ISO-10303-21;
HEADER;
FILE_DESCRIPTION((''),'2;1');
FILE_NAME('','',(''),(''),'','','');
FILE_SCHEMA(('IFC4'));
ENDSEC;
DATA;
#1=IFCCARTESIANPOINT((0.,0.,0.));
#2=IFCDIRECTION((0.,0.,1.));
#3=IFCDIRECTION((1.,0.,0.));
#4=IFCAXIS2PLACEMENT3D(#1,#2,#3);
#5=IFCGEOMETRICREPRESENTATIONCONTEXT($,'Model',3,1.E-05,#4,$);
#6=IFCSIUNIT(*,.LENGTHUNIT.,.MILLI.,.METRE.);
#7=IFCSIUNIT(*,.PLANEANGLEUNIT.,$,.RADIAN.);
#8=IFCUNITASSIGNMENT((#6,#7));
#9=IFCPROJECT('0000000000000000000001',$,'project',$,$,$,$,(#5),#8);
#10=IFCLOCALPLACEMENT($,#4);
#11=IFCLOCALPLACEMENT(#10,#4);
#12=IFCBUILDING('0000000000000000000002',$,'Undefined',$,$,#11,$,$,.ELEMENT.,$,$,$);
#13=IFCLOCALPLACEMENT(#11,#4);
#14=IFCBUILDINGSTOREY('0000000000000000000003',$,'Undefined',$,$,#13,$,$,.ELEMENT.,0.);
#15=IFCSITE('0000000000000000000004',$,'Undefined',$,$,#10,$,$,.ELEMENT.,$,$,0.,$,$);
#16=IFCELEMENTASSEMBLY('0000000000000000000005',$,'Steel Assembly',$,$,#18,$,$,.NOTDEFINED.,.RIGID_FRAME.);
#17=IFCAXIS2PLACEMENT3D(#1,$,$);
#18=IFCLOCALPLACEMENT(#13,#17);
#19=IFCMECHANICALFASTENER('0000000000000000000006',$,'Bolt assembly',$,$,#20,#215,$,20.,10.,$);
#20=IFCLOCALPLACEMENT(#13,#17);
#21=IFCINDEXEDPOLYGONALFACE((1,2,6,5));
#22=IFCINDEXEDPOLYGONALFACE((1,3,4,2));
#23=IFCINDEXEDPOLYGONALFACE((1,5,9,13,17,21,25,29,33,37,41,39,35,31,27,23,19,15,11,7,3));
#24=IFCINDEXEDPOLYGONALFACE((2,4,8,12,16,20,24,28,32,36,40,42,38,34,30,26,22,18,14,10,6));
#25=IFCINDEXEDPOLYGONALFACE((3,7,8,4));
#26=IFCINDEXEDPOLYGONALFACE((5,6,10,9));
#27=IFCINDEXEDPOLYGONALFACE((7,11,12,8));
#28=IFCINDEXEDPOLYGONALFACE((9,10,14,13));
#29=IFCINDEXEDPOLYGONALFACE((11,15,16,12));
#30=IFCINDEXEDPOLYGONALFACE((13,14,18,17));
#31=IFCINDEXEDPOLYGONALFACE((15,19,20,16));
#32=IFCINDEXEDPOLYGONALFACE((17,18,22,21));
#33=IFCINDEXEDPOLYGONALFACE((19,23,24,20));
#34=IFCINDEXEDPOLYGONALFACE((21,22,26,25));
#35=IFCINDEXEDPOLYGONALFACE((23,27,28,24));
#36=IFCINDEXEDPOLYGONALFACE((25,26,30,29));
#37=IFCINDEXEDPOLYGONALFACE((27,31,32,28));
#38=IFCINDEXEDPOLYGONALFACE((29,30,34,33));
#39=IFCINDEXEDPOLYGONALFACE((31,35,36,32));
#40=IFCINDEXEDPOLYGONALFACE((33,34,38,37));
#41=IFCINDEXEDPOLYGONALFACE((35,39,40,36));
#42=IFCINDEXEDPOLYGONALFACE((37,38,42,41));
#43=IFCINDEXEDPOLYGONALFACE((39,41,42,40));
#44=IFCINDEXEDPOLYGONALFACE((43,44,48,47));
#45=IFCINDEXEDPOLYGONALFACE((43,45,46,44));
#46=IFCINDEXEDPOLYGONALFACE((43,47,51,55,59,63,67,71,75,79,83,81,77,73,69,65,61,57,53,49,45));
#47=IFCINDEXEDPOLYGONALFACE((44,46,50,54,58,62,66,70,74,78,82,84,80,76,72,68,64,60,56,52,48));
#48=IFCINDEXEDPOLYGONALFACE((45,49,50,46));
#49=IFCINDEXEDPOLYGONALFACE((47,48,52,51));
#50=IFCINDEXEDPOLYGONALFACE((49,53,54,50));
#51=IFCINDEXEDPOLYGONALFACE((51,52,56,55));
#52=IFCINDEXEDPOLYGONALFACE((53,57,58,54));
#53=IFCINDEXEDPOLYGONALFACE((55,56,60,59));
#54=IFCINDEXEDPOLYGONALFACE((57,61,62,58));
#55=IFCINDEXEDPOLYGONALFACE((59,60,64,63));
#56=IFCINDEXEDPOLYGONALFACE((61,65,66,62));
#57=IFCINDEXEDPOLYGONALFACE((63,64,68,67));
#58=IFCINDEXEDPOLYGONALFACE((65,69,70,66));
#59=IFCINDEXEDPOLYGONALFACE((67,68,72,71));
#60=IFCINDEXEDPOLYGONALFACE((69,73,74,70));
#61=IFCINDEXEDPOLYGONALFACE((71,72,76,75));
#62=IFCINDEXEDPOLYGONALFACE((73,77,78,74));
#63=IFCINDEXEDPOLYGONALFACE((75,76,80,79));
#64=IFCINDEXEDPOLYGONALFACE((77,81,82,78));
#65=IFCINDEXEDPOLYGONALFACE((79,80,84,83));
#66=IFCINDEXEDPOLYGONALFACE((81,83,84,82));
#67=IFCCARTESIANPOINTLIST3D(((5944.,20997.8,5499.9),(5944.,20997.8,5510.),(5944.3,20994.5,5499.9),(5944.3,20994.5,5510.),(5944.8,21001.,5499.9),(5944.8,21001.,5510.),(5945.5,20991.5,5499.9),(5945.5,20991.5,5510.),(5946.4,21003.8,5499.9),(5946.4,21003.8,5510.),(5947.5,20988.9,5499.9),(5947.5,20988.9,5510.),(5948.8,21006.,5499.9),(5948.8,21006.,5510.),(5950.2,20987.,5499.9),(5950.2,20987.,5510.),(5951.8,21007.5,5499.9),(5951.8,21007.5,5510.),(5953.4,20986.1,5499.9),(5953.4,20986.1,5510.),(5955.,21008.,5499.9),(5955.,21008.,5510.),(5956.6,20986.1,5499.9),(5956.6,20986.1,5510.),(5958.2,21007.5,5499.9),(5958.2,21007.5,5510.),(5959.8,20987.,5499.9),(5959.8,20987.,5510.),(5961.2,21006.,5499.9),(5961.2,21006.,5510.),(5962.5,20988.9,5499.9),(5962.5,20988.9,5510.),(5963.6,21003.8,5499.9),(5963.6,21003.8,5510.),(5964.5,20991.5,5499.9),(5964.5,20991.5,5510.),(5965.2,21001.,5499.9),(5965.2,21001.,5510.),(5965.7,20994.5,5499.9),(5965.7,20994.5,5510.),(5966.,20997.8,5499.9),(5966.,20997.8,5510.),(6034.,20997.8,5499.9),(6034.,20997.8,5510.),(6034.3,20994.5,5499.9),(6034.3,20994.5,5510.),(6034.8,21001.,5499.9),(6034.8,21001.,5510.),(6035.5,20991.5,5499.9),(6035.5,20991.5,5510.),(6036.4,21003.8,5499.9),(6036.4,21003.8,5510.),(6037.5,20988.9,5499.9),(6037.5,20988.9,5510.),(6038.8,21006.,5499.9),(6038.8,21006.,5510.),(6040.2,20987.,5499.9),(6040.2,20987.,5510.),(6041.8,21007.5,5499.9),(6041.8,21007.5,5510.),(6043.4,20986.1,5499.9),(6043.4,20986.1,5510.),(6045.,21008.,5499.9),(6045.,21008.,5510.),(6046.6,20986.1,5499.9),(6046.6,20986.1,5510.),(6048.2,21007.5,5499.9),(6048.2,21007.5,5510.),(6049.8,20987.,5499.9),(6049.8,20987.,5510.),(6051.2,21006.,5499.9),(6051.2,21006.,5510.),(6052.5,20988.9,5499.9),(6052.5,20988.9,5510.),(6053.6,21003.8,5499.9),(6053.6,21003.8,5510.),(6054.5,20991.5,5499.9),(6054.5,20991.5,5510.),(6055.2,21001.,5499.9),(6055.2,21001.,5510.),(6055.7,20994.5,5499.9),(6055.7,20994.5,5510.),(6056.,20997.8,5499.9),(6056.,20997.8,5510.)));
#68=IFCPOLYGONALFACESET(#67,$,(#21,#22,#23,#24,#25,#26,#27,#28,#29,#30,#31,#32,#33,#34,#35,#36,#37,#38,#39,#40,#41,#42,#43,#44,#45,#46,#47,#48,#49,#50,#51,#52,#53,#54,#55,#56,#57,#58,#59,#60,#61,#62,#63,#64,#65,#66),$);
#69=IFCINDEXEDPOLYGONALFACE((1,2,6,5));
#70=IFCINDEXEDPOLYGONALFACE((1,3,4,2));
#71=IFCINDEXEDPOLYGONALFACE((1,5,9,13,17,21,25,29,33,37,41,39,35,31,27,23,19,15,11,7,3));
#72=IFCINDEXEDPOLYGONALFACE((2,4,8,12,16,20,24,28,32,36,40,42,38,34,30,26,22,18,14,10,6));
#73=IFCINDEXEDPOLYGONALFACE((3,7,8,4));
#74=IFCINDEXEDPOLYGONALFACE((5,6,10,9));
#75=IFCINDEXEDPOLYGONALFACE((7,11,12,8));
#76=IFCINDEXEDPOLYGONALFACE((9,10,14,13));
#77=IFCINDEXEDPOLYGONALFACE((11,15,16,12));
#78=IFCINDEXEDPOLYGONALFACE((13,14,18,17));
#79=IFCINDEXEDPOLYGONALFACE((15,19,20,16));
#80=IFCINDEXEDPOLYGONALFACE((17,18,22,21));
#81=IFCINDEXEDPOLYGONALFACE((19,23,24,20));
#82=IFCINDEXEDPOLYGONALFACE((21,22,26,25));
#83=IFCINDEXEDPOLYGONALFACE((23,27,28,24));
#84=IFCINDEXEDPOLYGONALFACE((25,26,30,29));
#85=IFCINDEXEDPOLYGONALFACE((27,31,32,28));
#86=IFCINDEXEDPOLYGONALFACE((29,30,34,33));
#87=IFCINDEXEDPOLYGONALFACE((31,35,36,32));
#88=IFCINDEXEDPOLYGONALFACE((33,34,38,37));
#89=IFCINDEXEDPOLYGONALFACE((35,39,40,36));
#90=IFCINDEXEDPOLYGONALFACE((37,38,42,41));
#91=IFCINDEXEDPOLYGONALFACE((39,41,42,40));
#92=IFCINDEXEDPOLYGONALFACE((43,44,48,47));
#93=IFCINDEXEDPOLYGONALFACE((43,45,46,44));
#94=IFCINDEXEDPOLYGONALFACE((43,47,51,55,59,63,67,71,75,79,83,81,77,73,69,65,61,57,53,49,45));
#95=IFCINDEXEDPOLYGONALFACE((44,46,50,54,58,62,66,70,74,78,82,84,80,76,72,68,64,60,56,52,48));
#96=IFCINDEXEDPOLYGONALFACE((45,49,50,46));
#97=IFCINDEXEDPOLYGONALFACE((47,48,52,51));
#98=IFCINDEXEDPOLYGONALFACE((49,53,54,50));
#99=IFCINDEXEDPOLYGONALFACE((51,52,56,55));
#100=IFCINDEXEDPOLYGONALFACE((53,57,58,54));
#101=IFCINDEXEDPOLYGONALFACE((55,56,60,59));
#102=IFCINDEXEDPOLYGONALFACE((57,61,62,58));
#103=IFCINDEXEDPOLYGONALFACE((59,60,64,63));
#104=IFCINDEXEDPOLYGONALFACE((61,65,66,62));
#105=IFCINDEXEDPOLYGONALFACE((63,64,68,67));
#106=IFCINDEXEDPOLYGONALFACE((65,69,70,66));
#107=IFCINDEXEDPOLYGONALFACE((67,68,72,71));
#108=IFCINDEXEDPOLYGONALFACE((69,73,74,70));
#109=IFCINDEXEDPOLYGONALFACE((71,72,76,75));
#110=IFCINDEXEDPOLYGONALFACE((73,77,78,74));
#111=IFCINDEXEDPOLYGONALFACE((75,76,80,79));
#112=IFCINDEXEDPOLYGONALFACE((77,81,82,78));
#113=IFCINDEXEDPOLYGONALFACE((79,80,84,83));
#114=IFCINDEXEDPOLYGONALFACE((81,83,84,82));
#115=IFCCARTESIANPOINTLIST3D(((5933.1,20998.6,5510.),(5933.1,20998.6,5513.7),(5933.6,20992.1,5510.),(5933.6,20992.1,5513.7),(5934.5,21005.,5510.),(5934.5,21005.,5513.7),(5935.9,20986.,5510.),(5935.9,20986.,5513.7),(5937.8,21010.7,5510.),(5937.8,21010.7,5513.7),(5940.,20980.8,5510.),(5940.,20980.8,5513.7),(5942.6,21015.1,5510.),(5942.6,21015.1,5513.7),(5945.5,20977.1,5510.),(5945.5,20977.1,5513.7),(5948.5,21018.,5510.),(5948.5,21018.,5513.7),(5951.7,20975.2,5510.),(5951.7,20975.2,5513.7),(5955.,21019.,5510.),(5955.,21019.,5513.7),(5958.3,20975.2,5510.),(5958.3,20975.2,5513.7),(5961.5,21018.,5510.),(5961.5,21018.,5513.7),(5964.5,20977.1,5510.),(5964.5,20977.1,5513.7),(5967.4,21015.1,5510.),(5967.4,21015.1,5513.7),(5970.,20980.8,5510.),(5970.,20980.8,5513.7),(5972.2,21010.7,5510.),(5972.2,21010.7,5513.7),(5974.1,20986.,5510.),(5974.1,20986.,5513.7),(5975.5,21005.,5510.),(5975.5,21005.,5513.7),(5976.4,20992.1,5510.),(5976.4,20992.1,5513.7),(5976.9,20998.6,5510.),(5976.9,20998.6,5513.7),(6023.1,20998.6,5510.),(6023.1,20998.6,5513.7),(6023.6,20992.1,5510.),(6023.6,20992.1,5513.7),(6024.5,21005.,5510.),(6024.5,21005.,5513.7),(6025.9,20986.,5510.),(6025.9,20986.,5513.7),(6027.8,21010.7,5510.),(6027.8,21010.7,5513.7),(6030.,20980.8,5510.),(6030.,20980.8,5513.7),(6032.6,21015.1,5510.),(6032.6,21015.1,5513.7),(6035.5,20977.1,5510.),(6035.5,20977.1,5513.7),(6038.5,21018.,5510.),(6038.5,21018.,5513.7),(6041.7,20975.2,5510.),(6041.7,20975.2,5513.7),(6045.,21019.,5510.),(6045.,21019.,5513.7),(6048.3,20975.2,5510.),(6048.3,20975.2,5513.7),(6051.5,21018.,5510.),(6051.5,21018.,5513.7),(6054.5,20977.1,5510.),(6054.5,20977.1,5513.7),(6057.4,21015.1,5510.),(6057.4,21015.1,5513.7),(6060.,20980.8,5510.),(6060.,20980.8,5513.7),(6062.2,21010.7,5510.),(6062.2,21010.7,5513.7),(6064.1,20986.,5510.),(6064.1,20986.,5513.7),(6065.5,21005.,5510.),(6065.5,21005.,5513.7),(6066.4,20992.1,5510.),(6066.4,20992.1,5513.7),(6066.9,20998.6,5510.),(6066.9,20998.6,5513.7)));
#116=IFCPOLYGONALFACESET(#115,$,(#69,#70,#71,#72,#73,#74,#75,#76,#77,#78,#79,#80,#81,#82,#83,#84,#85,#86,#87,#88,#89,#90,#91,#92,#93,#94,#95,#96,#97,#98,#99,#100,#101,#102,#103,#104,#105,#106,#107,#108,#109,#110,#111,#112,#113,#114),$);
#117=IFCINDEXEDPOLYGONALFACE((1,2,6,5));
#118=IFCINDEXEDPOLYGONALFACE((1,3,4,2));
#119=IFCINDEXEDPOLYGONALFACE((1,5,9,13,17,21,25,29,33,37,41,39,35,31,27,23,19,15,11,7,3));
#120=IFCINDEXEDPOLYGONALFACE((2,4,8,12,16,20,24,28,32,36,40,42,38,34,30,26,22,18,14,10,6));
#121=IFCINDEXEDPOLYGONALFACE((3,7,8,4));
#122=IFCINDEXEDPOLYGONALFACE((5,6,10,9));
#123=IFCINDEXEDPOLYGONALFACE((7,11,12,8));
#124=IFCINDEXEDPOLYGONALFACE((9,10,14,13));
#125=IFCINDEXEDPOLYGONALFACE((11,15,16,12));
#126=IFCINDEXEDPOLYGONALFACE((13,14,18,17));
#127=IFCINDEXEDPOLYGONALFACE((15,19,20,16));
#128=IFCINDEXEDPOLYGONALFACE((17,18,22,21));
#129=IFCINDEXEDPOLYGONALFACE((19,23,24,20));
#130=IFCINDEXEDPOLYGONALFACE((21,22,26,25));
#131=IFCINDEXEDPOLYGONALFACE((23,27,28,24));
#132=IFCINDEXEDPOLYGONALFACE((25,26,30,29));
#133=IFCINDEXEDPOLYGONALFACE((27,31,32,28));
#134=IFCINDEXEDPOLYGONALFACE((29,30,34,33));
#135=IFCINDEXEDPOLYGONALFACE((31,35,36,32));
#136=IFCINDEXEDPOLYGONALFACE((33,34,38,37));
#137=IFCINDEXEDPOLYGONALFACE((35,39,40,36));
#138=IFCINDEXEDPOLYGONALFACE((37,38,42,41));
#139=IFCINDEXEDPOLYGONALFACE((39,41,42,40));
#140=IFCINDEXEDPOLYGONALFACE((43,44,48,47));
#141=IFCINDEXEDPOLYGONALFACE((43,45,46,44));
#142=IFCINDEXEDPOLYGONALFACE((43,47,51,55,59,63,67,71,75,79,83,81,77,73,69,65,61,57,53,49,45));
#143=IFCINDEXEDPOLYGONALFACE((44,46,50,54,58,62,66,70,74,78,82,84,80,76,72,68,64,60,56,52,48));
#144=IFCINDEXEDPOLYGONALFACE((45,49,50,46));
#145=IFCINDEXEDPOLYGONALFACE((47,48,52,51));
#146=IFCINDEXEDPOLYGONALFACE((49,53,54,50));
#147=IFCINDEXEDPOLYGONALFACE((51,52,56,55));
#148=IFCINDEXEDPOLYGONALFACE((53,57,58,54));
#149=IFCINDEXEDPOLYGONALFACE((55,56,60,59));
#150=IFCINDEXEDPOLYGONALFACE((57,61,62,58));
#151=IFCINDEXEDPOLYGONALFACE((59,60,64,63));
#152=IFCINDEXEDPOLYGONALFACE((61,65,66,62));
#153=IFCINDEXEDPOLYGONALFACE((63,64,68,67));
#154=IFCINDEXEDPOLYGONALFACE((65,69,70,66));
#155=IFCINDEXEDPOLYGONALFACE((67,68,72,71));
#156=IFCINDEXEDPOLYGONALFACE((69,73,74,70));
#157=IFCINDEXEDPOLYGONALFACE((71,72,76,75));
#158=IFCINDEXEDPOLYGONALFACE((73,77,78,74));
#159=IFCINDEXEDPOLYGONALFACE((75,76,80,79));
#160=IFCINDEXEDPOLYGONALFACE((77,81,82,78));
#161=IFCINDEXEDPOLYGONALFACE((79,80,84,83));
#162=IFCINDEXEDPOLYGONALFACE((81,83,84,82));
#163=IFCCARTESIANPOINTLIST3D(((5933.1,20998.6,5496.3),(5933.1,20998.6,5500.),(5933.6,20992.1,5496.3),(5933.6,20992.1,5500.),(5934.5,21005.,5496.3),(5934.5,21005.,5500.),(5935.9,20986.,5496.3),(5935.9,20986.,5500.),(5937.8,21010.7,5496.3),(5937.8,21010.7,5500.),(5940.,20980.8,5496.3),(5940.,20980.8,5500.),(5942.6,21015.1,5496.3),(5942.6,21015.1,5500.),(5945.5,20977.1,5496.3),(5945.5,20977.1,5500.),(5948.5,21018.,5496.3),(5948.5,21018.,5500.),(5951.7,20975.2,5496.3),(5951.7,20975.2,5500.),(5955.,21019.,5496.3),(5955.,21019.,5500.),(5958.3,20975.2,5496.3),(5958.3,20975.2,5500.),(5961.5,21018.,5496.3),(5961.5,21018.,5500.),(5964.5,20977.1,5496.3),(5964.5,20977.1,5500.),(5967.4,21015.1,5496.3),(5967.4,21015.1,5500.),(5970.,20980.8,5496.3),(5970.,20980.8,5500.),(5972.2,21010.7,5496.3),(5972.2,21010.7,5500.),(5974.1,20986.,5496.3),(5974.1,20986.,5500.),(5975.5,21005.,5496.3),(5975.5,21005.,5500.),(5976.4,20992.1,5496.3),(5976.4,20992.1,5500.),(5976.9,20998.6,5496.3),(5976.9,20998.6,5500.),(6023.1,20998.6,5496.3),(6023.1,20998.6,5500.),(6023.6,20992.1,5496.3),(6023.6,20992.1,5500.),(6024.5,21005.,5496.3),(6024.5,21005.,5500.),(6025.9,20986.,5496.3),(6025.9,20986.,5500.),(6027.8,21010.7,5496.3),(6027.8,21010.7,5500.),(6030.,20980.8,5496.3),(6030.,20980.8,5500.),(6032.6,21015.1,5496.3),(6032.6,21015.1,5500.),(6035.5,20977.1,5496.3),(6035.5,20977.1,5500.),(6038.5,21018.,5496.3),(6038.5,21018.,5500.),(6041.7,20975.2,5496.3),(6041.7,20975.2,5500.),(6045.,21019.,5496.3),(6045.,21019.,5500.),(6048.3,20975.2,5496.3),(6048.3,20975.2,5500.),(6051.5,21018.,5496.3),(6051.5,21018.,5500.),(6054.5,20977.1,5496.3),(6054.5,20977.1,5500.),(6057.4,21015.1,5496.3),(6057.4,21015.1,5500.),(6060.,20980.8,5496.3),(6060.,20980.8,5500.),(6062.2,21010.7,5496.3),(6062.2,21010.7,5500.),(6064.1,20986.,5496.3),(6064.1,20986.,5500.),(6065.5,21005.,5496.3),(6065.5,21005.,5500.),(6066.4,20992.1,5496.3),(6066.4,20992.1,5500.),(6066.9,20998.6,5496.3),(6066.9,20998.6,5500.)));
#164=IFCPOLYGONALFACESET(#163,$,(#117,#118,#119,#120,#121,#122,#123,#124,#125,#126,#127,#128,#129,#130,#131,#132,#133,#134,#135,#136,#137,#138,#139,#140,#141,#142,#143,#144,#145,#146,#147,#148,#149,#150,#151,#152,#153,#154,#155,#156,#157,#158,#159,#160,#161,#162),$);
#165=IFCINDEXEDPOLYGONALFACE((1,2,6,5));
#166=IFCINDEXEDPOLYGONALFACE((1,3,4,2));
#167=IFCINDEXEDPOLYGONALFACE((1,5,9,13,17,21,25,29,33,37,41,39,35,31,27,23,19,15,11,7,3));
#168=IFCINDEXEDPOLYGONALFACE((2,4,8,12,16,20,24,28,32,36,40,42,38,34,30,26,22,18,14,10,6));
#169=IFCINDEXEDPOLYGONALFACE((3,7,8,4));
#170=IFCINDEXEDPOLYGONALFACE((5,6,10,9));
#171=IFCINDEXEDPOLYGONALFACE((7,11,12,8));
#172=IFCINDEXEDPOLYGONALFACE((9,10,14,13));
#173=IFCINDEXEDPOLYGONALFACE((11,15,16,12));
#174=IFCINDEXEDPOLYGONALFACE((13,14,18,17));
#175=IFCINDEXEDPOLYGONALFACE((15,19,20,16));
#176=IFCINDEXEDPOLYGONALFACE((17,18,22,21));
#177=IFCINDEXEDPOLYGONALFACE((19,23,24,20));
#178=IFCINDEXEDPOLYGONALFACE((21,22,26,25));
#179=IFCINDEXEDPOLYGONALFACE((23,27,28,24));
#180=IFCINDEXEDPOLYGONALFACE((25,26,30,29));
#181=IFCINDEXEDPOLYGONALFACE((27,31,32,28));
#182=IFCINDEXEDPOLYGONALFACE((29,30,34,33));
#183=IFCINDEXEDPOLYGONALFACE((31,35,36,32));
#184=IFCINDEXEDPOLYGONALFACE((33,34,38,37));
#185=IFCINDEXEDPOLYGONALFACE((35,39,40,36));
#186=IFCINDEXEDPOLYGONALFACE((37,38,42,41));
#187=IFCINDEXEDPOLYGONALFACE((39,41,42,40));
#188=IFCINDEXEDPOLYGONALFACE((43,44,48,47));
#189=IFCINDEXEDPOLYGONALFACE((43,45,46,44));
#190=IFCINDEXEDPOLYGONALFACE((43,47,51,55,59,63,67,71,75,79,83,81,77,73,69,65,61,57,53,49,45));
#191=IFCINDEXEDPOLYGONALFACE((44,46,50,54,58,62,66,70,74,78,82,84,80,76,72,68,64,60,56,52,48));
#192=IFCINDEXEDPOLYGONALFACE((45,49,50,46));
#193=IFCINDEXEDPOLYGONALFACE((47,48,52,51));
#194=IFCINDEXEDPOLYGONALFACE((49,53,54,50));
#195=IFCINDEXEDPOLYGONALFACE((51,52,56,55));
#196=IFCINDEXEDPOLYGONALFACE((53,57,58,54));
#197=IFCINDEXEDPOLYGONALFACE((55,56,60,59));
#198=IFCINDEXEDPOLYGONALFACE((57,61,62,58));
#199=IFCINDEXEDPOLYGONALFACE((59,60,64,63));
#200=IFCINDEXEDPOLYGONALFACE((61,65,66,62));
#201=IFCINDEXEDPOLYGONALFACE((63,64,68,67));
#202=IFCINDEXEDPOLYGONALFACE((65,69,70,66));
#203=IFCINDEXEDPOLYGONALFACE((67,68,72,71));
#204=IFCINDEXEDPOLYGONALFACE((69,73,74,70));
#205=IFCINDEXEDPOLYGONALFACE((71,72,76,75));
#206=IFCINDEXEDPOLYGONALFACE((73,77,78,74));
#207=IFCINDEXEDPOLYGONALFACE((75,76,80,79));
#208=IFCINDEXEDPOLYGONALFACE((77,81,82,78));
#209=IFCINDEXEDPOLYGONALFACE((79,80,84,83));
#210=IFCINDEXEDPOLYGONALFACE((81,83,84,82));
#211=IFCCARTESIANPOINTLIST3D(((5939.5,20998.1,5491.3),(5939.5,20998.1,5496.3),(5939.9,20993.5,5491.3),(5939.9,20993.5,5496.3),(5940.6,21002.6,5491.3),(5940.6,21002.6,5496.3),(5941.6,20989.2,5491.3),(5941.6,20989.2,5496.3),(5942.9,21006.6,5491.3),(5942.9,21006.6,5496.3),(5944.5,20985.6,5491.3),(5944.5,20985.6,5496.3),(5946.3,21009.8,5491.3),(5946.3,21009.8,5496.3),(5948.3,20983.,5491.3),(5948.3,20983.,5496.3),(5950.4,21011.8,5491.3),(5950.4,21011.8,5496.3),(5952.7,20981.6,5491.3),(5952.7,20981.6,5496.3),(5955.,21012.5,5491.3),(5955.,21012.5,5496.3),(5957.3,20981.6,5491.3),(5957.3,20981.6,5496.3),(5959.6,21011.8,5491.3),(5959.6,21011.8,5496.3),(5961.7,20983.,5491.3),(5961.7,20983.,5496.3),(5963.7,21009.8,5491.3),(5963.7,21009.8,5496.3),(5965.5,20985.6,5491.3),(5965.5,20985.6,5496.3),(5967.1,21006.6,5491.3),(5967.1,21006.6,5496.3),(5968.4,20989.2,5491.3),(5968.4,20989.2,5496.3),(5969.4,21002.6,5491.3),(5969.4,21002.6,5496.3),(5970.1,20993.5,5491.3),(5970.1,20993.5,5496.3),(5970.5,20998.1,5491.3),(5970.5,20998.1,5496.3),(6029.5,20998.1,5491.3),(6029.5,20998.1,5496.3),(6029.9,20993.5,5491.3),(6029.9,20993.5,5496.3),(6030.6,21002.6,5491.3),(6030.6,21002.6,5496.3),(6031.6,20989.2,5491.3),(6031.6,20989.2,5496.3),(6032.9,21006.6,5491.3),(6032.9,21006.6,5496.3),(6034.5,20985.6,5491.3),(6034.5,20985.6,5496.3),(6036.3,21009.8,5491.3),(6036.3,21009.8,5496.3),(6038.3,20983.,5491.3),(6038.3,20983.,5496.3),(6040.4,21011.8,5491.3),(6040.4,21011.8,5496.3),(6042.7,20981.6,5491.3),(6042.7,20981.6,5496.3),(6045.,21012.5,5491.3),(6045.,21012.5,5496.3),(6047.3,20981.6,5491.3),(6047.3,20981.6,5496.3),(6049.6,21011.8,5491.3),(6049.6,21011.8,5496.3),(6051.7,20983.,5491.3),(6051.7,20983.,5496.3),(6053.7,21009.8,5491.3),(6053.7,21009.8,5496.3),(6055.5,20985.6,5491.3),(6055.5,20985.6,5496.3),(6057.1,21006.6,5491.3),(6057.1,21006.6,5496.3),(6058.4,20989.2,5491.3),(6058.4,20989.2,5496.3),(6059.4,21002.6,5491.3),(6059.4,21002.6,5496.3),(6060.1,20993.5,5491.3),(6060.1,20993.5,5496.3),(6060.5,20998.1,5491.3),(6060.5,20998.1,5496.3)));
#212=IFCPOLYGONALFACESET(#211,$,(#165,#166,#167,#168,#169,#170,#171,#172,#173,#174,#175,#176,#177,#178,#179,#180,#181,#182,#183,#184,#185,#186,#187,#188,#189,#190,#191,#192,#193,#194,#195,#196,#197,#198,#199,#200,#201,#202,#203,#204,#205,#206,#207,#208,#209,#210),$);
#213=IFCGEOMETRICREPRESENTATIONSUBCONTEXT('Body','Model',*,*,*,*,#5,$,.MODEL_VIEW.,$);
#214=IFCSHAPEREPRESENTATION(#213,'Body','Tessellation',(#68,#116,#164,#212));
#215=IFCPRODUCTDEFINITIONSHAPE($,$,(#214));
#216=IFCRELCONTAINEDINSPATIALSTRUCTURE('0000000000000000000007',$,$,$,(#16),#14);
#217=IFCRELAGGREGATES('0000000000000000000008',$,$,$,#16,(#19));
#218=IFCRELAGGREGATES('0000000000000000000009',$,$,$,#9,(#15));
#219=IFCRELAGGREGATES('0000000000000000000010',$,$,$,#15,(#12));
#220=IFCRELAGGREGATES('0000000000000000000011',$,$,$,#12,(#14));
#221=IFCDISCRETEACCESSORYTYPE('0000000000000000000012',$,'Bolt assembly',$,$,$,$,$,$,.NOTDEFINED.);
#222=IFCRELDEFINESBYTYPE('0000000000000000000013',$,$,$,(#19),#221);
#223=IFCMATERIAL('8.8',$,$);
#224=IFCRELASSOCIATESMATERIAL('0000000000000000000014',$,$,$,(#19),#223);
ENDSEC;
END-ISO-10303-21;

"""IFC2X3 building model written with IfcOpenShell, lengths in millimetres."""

from ifc_helpers import new_model, si_unit, frame, origin_with_axes, origin_2d_with_axis, place, context, subcontext, project, spatial, circle, extrude, source, transform, mapped, material, type_object, element, aggregate, save


model = new_model("IFC2X3")

# Units and contexts
model_context = context("Model", 3, precision=1e-05, world=origin_with_axes())
body_context = subcontext(model_context, "Body", "Model", "MODEL_VIEW")
ifc_project = project(units=[si_unit("LENGTHUNIT", "METRE", prefix="MILLI"), si_unit("PLANEANGLEUNIT", "RADIAN")], contexts=[model_context])

# Site, building, storey
site_placement = place(None, origin_with_axes())
site = spatial("IfcSite", under=ifc_project, at=site_placement, Name="Undefined", CompositionType="ELEMENT", RefElevation=0.0)
building_placement = place(site_placement, origin_with_axes())
building = spatial("IfcBuilding", under=site, at=building_placement, Name="Undefined", CompositionType="ELEMENT")
storey_placement = place(building_placement, origin_with_axes())
storey = spatial("IfcBuildingStorey", under=building, at=storey_placement, Name="Undefined", CompositionType="ELEMENT", Elevation=0.0)

# Element assembly
assembly_1_placement = place(storey_placement, origin_with_axes())
assembly_1 = element("IfcElementAssembly", 1, at=assembly_1_placement, inside=storey, Name="Steel Assembly", AssemblyPlace="NOTDEFINED", PredefinedType="RIGID_FRAME")

# Mechanical fastener
ifc_material_1 = material(Name="8.8")
discrete_accessory_type_1 = type_object("IfcDiscreteAccessoryType", Name="Bolt assembly")
shared_shape = source(origin_with_axes(), body_context, "Body", "SweptSolid", [
    extrude(circle(Radius=11.0, at=origin_2d_with_axis()), frame((0.0, -10.0, 0.0), z_axis=(0.0, 1.0, 0.0), x_axis=(1.0, 0.0, 0.0)), (0.0, 0.0, 1.0), 10.1),
    extrude(circle(Radius=22.0, at=origin_2d_with_axis()), frame((0.0, -13.7, 0.0), z_axis=(0.0, 1.0, 0.0), x_axis=(1.0, 0.0, 0.0)), (0.0, 0.0, 1.0), 3.7),
    extrude(circle(Radius=22.0, at=origin_2d_with_axis()), frame((0.0, 0.0, 0.0), z_axis=(0.0, 1.0, 0.0), x_axis=(1.0, 0.0, 0.0)), (0.0, 0.0, 1.0), 3.7),
    extrude(circle(Radius=15.5, at=origin_2d_with_axis()), frame((0.0, 3.7, 0.0), z_axis=(0.0, 1.0, 0.0), x_axis=(1.0, 0.0, 0.0)), (0.0, 0.0, 1.0), 5.0),
])
mechanical_fastener_1_placement = place(assembly_1_placement, frame((6000.0, 20997.0, 5500.0), z_axis=(-1.0, 0.0, 0.0), x_axis=(0.0, 1.0, 0.0)))
mechanical_fastener_1 = element("IfcMechanicalFastener", 2, at=mechanical_fastener_1_placement, type_object=discrete_accessory_type_1, material=ifc_material_1, Name="Bolt assembly", NominalDiameter=20.0, NominalLength=10.0, context=body_context, shape_type="MappedRepresentation", body=[
    mapped(shared_shape, transform((0.0, 0.0, -45.0))),
    mapped(shared_shape, transform((0.0, 0.0, 45.0))),
])
aggregate(assembly_1, [mechanical_fastener_1])

save(model, "model.ifc")
